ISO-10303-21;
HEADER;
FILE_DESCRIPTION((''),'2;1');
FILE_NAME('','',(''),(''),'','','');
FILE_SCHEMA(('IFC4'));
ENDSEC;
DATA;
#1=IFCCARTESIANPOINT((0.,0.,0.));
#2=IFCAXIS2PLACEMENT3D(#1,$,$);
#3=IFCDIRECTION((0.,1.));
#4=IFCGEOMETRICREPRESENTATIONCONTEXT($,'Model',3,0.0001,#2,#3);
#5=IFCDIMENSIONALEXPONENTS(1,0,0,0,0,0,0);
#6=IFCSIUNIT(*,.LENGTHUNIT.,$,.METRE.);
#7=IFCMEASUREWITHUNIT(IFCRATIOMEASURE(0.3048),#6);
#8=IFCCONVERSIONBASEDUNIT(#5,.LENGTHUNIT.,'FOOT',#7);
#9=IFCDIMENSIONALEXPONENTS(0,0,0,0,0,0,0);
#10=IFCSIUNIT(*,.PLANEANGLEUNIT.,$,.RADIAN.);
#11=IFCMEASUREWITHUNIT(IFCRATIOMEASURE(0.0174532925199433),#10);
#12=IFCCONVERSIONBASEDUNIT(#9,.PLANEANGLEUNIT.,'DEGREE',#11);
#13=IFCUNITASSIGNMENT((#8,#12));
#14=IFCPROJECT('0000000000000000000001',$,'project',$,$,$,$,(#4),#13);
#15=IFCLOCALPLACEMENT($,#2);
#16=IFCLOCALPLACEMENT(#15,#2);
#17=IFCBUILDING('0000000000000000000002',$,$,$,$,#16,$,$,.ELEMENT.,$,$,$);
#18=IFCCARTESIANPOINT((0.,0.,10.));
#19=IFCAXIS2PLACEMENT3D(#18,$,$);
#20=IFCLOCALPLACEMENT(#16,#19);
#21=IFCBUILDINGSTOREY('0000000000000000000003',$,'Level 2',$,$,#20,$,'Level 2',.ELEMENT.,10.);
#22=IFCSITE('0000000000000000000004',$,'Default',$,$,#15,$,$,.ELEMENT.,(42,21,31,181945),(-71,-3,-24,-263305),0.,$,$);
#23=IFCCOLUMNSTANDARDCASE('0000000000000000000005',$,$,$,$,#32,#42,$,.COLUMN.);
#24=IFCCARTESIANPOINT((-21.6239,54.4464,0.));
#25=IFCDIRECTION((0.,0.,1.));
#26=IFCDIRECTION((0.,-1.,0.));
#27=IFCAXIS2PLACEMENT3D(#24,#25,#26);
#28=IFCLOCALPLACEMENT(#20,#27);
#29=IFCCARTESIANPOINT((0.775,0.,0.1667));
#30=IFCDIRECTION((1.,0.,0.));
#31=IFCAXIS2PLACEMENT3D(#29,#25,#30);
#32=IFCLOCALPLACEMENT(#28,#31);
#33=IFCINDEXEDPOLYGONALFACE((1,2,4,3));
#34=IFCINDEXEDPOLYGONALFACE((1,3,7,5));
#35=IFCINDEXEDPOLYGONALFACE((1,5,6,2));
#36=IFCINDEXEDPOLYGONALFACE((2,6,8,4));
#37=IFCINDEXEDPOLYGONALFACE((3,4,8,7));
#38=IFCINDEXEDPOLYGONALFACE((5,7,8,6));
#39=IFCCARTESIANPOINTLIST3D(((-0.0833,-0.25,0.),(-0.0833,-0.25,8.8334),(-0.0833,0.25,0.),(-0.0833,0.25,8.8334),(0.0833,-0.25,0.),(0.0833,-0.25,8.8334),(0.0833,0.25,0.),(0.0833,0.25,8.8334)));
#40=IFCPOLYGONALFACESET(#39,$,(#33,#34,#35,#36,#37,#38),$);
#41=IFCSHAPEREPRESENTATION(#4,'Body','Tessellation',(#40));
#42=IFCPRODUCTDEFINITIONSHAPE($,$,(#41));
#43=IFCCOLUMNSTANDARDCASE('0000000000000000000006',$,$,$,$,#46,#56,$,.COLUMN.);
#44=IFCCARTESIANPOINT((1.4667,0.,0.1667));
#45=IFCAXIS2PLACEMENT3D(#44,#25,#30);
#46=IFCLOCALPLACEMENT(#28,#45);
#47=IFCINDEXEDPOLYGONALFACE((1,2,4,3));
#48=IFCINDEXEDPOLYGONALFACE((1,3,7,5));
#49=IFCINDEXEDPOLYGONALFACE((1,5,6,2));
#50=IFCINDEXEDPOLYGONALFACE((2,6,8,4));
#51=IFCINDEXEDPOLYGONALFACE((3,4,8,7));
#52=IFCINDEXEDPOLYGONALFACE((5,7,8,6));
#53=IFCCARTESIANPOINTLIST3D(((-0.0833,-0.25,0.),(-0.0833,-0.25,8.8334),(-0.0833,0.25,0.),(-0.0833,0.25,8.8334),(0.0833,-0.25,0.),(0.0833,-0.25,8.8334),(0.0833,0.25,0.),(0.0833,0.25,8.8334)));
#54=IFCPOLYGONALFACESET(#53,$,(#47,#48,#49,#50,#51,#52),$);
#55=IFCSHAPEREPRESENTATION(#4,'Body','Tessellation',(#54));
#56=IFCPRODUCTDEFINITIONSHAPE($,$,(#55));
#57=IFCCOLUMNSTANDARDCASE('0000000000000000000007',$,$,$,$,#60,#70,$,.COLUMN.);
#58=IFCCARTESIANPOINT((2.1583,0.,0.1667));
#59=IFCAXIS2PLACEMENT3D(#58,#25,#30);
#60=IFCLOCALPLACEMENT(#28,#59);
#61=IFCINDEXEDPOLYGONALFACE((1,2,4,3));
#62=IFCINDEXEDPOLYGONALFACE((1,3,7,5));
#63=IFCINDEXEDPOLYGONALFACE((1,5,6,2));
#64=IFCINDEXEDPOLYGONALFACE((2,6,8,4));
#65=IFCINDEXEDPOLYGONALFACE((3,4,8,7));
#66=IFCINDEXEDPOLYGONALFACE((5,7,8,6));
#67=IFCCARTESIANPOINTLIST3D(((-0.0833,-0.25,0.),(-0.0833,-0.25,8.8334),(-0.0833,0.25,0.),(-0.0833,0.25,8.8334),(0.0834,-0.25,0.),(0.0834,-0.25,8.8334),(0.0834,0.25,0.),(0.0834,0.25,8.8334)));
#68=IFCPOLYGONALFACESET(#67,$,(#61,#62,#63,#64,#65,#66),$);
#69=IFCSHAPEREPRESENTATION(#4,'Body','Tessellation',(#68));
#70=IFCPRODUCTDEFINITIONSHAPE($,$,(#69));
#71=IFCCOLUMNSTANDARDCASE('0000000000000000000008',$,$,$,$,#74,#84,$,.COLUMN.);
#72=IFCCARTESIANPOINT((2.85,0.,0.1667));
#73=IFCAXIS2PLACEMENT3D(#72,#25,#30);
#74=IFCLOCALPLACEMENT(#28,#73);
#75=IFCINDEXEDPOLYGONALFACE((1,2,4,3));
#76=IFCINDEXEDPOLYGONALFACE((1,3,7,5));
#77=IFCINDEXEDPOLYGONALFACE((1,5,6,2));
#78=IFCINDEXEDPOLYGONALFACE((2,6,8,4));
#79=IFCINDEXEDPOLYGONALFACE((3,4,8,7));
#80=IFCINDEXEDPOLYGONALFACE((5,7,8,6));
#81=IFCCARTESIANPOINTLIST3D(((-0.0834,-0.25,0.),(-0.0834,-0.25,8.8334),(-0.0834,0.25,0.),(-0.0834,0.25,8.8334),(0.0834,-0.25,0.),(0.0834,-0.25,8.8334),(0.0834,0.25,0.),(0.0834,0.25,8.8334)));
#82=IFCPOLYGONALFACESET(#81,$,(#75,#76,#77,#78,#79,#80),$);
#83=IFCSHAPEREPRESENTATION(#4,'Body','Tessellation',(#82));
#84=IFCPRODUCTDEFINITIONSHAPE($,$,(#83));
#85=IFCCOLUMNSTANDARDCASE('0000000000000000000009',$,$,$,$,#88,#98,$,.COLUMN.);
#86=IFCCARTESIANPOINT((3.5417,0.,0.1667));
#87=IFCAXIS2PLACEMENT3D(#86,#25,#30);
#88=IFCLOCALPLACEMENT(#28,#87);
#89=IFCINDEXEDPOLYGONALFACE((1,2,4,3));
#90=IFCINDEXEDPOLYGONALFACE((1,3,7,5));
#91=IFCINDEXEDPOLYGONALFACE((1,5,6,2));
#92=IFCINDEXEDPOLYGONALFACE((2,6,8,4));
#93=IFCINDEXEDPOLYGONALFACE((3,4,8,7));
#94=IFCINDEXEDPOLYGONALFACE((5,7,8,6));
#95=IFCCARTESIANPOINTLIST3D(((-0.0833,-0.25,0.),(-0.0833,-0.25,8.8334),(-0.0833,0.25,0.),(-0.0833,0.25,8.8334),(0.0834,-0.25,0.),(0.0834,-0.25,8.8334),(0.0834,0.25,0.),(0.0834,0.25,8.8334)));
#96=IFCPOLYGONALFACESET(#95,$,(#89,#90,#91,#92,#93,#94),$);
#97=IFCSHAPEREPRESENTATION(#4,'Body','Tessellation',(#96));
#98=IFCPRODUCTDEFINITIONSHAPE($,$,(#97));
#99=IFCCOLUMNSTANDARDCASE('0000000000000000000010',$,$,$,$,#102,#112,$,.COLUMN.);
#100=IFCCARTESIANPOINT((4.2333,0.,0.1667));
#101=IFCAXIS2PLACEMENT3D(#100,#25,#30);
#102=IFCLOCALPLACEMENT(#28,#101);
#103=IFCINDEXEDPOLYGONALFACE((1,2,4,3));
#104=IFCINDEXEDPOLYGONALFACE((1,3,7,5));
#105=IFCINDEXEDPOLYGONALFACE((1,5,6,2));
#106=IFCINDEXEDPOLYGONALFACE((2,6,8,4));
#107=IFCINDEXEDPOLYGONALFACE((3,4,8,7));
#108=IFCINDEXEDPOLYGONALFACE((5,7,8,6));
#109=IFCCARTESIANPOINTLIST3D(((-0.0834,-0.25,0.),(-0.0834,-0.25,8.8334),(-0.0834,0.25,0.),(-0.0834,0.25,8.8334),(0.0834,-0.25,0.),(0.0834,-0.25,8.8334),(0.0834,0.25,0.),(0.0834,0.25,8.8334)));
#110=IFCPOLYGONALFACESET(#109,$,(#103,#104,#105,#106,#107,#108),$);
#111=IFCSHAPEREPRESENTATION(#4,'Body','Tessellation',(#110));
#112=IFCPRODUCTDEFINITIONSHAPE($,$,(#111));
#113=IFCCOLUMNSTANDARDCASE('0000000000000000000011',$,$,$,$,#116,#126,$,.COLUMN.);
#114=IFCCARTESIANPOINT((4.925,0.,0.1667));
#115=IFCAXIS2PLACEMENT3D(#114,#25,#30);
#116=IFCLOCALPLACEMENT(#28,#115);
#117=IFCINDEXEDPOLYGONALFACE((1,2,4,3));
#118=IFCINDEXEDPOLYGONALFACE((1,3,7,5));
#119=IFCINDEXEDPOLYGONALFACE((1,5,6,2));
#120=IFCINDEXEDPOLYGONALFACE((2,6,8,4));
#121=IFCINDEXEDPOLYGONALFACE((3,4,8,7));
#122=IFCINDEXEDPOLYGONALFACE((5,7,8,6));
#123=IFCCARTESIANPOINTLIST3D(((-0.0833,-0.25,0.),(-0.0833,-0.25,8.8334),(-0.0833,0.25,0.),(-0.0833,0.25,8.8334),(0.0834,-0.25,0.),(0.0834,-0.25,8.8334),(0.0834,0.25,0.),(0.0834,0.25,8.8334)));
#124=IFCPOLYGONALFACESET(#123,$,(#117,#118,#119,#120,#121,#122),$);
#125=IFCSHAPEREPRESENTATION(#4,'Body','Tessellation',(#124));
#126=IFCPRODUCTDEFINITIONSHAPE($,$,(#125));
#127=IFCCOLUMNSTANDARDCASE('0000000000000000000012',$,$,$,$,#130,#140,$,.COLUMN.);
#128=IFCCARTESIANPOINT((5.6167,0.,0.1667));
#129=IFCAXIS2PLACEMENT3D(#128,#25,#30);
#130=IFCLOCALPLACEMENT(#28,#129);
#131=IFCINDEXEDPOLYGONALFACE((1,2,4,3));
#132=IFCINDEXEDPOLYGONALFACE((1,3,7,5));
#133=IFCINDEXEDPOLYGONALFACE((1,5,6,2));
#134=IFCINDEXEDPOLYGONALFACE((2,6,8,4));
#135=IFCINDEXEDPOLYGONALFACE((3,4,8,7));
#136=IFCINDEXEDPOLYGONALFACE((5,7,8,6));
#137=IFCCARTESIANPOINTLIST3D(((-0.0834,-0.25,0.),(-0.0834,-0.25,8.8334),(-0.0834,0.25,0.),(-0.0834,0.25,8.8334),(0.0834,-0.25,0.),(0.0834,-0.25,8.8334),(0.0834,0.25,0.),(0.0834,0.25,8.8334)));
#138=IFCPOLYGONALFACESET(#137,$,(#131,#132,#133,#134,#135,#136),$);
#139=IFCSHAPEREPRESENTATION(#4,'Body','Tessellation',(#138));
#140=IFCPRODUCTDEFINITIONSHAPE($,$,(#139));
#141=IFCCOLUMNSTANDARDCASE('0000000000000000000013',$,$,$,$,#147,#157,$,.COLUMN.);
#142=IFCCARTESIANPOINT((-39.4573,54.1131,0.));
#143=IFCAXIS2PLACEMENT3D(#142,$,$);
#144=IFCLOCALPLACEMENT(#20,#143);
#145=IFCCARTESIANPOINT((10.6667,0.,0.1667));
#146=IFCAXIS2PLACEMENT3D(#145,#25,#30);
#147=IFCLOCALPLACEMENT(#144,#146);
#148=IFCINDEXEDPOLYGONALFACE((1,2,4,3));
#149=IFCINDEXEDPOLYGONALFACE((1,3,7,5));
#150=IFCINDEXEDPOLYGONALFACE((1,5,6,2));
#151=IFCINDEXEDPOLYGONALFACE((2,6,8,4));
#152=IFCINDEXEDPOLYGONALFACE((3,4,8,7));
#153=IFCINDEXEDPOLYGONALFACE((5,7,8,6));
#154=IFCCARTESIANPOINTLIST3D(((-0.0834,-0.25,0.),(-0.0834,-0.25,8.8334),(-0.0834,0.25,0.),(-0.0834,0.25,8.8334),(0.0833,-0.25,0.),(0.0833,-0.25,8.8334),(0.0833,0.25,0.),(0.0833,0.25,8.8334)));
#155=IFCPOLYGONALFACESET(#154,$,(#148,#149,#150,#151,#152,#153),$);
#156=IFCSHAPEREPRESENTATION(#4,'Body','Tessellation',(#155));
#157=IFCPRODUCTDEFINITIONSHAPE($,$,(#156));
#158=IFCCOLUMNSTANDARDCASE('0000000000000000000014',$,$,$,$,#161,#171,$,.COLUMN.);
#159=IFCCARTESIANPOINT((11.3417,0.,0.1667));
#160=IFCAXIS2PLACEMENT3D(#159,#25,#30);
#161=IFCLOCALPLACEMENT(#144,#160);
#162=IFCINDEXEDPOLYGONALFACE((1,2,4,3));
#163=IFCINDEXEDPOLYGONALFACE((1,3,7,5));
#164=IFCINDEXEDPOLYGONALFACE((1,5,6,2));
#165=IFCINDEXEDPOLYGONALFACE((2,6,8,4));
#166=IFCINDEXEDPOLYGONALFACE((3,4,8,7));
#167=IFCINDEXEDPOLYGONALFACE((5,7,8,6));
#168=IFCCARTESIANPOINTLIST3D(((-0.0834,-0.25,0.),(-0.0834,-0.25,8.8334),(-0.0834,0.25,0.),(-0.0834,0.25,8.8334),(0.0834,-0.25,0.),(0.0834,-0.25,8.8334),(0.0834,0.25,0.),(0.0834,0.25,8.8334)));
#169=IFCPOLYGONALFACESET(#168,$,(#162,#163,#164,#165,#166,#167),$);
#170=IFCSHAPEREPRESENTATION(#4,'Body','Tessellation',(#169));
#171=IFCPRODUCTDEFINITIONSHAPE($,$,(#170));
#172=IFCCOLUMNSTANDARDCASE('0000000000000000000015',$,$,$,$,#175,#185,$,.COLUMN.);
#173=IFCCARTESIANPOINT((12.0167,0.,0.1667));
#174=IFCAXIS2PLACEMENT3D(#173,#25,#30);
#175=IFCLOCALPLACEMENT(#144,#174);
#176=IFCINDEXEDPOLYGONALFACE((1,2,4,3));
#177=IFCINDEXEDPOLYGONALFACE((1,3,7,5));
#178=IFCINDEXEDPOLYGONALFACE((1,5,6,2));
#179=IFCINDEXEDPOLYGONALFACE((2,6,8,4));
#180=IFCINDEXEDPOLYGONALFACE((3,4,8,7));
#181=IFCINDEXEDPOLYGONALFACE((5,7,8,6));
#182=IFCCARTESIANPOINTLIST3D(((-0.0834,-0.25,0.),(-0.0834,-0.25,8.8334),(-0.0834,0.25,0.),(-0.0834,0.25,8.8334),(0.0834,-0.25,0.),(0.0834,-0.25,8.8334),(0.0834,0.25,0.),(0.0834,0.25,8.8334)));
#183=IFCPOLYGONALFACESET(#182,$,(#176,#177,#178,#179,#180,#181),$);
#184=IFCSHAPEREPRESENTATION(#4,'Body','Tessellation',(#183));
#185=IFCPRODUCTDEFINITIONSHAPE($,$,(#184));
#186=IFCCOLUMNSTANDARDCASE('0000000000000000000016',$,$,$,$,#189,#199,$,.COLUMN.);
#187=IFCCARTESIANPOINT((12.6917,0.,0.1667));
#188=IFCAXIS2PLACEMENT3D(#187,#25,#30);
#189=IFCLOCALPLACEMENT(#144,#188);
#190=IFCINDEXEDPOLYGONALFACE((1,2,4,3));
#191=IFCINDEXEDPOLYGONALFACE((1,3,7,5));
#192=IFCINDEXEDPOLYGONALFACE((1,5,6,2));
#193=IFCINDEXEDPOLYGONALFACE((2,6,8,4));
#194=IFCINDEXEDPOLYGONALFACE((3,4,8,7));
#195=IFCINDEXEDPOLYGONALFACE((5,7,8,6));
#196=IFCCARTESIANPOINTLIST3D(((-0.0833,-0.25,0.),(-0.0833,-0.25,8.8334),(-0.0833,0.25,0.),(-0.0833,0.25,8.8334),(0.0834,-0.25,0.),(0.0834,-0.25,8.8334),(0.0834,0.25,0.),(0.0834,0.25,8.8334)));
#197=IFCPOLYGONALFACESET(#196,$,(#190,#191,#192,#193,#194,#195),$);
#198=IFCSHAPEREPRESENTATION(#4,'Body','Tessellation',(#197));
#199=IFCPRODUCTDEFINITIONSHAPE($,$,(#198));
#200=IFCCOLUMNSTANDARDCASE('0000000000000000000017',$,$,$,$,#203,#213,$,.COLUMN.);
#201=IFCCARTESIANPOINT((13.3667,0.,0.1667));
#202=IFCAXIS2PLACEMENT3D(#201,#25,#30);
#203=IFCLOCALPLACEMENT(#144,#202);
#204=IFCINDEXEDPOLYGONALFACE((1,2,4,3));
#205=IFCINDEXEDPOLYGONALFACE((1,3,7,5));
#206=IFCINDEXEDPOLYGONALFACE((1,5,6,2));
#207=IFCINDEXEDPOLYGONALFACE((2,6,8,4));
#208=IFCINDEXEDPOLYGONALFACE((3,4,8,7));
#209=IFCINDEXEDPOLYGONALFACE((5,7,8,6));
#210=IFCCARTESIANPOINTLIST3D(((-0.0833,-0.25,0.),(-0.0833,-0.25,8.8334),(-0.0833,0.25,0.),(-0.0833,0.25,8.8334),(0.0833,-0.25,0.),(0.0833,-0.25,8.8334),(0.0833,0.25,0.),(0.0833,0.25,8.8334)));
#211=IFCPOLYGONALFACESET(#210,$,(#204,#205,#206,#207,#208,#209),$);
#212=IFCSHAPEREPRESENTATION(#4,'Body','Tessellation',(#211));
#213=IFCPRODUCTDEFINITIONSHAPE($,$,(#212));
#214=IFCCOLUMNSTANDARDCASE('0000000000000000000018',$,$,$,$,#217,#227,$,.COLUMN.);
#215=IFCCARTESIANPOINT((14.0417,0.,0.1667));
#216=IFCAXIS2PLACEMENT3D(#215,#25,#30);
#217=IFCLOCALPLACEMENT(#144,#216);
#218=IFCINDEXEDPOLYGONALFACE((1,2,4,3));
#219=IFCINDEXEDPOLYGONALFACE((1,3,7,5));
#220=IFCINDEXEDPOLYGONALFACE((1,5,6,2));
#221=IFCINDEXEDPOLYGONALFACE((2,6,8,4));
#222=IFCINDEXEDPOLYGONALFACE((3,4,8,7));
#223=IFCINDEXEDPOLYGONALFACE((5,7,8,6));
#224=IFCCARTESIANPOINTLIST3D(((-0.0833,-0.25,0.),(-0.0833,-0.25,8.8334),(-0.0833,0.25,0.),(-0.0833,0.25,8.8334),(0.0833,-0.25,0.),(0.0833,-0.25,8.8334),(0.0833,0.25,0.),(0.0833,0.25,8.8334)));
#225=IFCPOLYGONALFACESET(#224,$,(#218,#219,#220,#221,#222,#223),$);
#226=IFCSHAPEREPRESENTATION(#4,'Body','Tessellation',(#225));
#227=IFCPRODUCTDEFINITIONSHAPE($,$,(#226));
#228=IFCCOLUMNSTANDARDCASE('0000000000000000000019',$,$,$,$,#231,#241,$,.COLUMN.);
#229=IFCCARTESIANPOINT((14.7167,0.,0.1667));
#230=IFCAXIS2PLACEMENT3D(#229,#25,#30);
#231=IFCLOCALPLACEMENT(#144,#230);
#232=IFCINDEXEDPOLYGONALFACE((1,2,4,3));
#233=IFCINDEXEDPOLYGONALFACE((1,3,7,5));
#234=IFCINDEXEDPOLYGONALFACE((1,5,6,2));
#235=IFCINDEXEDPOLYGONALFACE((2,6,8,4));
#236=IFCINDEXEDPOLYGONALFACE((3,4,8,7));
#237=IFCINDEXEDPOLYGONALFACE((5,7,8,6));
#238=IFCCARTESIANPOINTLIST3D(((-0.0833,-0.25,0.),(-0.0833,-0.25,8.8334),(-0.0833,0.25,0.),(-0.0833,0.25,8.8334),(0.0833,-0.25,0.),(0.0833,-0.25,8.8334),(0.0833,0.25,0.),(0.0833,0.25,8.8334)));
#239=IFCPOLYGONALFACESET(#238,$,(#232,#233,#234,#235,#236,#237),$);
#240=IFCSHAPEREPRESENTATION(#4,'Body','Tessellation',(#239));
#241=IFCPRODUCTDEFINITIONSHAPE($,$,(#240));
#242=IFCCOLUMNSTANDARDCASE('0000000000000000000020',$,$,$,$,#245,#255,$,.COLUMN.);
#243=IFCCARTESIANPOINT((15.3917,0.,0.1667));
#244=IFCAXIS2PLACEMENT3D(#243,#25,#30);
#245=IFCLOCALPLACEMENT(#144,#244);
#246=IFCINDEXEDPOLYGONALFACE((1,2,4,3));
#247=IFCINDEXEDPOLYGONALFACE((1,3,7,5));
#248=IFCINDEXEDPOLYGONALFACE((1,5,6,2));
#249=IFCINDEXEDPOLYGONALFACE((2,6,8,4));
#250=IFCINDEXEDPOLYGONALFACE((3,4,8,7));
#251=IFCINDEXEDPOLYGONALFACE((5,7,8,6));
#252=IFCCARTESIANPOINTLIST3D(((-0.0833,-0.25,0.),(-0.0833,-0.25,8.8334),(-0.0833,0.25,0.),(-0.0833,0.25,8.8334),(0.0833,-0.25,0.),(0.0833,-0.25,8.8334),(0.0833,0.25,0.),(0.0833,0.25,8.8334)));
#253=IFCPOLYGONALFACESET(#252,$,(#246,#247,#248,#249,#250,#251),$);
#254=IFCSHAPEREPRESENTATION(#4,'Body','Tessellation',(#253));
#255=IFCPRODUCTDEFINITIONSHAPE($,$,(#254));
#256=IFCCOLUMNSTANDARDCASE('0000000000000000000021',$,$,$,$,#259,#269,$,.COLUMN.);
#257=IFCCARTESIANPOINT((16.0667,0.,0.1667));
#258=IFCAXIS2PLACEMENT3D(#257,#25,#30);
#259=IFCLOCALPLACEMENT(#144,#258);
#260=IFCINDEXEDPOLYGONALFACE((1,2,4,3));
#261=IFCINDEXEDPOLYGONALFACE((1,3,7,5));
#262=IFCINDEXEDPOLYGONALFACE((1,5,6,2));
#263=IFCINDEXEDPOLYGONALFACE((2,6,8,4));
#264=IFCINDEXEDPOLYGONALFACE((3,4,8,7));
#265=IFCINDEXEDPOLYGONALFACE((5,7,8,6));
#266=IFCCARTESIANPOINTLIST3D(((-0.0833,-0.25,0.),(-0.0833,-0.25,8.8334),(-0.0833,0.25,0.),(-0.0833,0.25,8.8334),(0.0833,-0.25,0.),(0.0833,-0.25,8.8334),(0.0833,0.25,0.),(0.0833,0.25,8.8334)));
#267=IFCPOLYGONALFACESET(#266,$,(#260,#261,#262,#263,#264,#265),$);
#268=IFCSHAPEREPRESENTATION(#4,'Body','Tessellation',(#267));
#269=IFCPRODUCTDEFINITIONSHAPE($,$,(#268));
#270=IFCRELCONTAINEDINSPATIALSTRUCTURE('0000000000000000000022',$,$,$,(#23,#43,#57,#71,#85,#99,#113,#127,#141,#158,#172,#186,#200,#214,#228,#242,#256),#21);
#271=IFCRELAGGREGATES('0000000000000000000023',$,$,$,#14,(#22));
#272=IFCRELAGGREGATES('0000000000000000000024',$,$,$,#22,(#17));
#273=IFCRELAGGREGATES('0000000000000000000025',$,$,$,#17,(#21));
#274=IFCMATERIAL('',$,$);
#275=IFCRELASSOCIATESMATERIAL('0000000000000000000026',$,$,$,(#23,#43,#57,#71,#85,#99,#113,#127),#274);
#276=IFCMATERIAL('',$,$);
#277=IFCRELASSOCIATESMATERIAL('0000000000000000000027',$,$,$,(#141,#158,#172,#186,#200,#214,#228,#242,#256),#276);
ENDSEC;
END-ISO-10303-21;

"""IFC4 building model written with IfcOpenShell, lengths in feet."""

from ifc_helpers import new_model, entity, si_unit, converted_unit, direction, frame, origin, place, context, project, spatial, rectangle, extrude, material, element, save


model = new_model("IFC4")

# Units and contexts
model_context = context("Model", 3, precision=0.0001, world=origin(), true_north=direction((0.0, 1.0)))
ifc_project = project(units=[converted_unit("LENGTHUNIT", "FOOT", entity("IfcRatioMeasure", 0.3048), si_unit("LENGTHUNIT", "METRE"), dimensions=[1, 0, 0, 0, 0, 0, 0]), converted_unit("PLANEANGLEUNIT", "DEGREE", entity("IfcRatioMeasure", 0.0174532925199433), si_unit("PLANEANGLEUNIT", "RADIAN"), dimensions=[0, 0, 0, 0, 0, 0, 0])], contexts=[model_context])

# Site, building, storey
site_placement = place(None, origin())
site = spatial("IfcSite", under=ifc_project, at=site_placement, Name="Default", CompositionType="ELEMENT", RefLatitude=(42, 21, 31, 181945), RefLongitude=(-71, -3, -24, -263305), RefElevation=0.0)
building_placement = place(site_placement, origin())
building = spatial("IfcBuilding", under=site, at=building_placement, CompositionType="ELEMENT")
storey_placement = place(building_placement, frame((0.0, 0.0, 10.0)))
storey = spatial("IfcBuildingStorey", under=building, at=storey_placement, Name="Level 2", LongName="Level 2", CompositionType="ELEMENT", Elevation=10.0)

# Columns
ifc_material_1 = material(Name="")
placement_1 = place(storey_placement, frame((-21.6239, 54.4464, 0.0), z_axis=(0.0, 0.0, 1.0), x_axis=(0.0, -1.0, 0.0)))
for number, where, z_axis, x_axis in (
    (1, (0.775, 0.0, 0.1667), (0.0, 0.0, 1.0), (1.0, 0.0, 0.0)),
    (2, (1.4667, 0.0, 0.1667), (0.0, 0.0, 1.0), (1.0, 0.0, 0.0)),
    (3, (2.1583, 0.0, 0.1667), (0.0, 0.0, 1.0), (1.0, 0.0, 0.0)),
    (4, (2.85, 0.0, 0.1667), (0.0, 0.0, 1.0), (1.0, 0.0, 0.0)),
    (5, (3.5417, 0.0, 0.1667), (0.0, 0.0, 1.0), (1.0, 0.0, 0.0)),
    (6, (4.2333, 0.0, 0.1667), (0.0, 0.0, 1.0), (1.0, 0.0, 0.0)),
    (7, (4.925, 0.0, 0.1667), (0.0, 0.0, 1.0), (1.0, 0.0, 0.0)),
    (8, (5.6167, 0.0, 0.1667), (0.0, 0.0, 1.0), (1.0, 0.0, 0.0)),
):
    element("IfcColumnStandardCase", number, at=place(placement_1, frame(where, z_axis=z_axis, x_axis=x_axis)), inside=storey, material=ifc_material_1, PredefinedType="COLUMN", context=model_context, shape_type="SweptSolid", body=[
        extrude(rectangle(XDim=0.1667, YDim=0.5), origin(), (0.0, 0.0, 1.0), 8.8334),
    ])
ifc_material_2 = material(Name="")
placement_2 = place(storey_placement, frame((-39.4573, 54.1131, 0.0)))
for number, where, z_axis, x_axis in (
    (9, (10.6667, 0.0, 0.1667), (0.0, 0.0, 1.0), (1.0, 0.0, 0.0)),
    (10, (11.3417, 0.0, 0.1667), (0.0, 0.0, 1.0), (1.0, 0.0, 0.0)),
    (11, (12.0167, 0.0, 0.1667), (0.0, 0.0, 1.0), (1.0, 0.0, 0.0)),
    (12, (12.6917, 0.0, 0.1667), (0.0, 0.0, 1.0), (1.0, 0.0, 0.0)),
    (13, (13.3667, 0.0, 0.1667), (0.0, 0.0, 1.0), (1.0, 0.0, 0.0)),
    (14, (14.0417, 0.0, 0.1667), (0.0, 0.0, 1.0), (1.0, 0.0, 0.0)),
    (15, (14.7167, 0.0, 0.1667), (0.0, 0.0, 1.0), (1.0, 0.0, 0.0)),
    (16, (15.3917, 0.0, 0.1667), (0.0, 0.0, 1.0), (1.0, 0.0, 0.0)),
    (17, (16.0667, 0.0, 0.1667), (0.0, 0.0, 1.0), (1.0, 0.0, 0.0)),
):
    element("IfcColumnStandardCase", number, at=place(placement_2, frame(where, z_axis=z_axis, x_axis=x_axis)), inside=storey, material=ifc_material_2, PredefinedType="COLUMN", context=model_context, shape_type="SweptSolid", body=[
        extrude(rectangle(XDim=0.1667, YDim=0.5), origin(), (0.0, 0.0, 1.0), 8.8334),
    ])

save(model, "model.ifc")
